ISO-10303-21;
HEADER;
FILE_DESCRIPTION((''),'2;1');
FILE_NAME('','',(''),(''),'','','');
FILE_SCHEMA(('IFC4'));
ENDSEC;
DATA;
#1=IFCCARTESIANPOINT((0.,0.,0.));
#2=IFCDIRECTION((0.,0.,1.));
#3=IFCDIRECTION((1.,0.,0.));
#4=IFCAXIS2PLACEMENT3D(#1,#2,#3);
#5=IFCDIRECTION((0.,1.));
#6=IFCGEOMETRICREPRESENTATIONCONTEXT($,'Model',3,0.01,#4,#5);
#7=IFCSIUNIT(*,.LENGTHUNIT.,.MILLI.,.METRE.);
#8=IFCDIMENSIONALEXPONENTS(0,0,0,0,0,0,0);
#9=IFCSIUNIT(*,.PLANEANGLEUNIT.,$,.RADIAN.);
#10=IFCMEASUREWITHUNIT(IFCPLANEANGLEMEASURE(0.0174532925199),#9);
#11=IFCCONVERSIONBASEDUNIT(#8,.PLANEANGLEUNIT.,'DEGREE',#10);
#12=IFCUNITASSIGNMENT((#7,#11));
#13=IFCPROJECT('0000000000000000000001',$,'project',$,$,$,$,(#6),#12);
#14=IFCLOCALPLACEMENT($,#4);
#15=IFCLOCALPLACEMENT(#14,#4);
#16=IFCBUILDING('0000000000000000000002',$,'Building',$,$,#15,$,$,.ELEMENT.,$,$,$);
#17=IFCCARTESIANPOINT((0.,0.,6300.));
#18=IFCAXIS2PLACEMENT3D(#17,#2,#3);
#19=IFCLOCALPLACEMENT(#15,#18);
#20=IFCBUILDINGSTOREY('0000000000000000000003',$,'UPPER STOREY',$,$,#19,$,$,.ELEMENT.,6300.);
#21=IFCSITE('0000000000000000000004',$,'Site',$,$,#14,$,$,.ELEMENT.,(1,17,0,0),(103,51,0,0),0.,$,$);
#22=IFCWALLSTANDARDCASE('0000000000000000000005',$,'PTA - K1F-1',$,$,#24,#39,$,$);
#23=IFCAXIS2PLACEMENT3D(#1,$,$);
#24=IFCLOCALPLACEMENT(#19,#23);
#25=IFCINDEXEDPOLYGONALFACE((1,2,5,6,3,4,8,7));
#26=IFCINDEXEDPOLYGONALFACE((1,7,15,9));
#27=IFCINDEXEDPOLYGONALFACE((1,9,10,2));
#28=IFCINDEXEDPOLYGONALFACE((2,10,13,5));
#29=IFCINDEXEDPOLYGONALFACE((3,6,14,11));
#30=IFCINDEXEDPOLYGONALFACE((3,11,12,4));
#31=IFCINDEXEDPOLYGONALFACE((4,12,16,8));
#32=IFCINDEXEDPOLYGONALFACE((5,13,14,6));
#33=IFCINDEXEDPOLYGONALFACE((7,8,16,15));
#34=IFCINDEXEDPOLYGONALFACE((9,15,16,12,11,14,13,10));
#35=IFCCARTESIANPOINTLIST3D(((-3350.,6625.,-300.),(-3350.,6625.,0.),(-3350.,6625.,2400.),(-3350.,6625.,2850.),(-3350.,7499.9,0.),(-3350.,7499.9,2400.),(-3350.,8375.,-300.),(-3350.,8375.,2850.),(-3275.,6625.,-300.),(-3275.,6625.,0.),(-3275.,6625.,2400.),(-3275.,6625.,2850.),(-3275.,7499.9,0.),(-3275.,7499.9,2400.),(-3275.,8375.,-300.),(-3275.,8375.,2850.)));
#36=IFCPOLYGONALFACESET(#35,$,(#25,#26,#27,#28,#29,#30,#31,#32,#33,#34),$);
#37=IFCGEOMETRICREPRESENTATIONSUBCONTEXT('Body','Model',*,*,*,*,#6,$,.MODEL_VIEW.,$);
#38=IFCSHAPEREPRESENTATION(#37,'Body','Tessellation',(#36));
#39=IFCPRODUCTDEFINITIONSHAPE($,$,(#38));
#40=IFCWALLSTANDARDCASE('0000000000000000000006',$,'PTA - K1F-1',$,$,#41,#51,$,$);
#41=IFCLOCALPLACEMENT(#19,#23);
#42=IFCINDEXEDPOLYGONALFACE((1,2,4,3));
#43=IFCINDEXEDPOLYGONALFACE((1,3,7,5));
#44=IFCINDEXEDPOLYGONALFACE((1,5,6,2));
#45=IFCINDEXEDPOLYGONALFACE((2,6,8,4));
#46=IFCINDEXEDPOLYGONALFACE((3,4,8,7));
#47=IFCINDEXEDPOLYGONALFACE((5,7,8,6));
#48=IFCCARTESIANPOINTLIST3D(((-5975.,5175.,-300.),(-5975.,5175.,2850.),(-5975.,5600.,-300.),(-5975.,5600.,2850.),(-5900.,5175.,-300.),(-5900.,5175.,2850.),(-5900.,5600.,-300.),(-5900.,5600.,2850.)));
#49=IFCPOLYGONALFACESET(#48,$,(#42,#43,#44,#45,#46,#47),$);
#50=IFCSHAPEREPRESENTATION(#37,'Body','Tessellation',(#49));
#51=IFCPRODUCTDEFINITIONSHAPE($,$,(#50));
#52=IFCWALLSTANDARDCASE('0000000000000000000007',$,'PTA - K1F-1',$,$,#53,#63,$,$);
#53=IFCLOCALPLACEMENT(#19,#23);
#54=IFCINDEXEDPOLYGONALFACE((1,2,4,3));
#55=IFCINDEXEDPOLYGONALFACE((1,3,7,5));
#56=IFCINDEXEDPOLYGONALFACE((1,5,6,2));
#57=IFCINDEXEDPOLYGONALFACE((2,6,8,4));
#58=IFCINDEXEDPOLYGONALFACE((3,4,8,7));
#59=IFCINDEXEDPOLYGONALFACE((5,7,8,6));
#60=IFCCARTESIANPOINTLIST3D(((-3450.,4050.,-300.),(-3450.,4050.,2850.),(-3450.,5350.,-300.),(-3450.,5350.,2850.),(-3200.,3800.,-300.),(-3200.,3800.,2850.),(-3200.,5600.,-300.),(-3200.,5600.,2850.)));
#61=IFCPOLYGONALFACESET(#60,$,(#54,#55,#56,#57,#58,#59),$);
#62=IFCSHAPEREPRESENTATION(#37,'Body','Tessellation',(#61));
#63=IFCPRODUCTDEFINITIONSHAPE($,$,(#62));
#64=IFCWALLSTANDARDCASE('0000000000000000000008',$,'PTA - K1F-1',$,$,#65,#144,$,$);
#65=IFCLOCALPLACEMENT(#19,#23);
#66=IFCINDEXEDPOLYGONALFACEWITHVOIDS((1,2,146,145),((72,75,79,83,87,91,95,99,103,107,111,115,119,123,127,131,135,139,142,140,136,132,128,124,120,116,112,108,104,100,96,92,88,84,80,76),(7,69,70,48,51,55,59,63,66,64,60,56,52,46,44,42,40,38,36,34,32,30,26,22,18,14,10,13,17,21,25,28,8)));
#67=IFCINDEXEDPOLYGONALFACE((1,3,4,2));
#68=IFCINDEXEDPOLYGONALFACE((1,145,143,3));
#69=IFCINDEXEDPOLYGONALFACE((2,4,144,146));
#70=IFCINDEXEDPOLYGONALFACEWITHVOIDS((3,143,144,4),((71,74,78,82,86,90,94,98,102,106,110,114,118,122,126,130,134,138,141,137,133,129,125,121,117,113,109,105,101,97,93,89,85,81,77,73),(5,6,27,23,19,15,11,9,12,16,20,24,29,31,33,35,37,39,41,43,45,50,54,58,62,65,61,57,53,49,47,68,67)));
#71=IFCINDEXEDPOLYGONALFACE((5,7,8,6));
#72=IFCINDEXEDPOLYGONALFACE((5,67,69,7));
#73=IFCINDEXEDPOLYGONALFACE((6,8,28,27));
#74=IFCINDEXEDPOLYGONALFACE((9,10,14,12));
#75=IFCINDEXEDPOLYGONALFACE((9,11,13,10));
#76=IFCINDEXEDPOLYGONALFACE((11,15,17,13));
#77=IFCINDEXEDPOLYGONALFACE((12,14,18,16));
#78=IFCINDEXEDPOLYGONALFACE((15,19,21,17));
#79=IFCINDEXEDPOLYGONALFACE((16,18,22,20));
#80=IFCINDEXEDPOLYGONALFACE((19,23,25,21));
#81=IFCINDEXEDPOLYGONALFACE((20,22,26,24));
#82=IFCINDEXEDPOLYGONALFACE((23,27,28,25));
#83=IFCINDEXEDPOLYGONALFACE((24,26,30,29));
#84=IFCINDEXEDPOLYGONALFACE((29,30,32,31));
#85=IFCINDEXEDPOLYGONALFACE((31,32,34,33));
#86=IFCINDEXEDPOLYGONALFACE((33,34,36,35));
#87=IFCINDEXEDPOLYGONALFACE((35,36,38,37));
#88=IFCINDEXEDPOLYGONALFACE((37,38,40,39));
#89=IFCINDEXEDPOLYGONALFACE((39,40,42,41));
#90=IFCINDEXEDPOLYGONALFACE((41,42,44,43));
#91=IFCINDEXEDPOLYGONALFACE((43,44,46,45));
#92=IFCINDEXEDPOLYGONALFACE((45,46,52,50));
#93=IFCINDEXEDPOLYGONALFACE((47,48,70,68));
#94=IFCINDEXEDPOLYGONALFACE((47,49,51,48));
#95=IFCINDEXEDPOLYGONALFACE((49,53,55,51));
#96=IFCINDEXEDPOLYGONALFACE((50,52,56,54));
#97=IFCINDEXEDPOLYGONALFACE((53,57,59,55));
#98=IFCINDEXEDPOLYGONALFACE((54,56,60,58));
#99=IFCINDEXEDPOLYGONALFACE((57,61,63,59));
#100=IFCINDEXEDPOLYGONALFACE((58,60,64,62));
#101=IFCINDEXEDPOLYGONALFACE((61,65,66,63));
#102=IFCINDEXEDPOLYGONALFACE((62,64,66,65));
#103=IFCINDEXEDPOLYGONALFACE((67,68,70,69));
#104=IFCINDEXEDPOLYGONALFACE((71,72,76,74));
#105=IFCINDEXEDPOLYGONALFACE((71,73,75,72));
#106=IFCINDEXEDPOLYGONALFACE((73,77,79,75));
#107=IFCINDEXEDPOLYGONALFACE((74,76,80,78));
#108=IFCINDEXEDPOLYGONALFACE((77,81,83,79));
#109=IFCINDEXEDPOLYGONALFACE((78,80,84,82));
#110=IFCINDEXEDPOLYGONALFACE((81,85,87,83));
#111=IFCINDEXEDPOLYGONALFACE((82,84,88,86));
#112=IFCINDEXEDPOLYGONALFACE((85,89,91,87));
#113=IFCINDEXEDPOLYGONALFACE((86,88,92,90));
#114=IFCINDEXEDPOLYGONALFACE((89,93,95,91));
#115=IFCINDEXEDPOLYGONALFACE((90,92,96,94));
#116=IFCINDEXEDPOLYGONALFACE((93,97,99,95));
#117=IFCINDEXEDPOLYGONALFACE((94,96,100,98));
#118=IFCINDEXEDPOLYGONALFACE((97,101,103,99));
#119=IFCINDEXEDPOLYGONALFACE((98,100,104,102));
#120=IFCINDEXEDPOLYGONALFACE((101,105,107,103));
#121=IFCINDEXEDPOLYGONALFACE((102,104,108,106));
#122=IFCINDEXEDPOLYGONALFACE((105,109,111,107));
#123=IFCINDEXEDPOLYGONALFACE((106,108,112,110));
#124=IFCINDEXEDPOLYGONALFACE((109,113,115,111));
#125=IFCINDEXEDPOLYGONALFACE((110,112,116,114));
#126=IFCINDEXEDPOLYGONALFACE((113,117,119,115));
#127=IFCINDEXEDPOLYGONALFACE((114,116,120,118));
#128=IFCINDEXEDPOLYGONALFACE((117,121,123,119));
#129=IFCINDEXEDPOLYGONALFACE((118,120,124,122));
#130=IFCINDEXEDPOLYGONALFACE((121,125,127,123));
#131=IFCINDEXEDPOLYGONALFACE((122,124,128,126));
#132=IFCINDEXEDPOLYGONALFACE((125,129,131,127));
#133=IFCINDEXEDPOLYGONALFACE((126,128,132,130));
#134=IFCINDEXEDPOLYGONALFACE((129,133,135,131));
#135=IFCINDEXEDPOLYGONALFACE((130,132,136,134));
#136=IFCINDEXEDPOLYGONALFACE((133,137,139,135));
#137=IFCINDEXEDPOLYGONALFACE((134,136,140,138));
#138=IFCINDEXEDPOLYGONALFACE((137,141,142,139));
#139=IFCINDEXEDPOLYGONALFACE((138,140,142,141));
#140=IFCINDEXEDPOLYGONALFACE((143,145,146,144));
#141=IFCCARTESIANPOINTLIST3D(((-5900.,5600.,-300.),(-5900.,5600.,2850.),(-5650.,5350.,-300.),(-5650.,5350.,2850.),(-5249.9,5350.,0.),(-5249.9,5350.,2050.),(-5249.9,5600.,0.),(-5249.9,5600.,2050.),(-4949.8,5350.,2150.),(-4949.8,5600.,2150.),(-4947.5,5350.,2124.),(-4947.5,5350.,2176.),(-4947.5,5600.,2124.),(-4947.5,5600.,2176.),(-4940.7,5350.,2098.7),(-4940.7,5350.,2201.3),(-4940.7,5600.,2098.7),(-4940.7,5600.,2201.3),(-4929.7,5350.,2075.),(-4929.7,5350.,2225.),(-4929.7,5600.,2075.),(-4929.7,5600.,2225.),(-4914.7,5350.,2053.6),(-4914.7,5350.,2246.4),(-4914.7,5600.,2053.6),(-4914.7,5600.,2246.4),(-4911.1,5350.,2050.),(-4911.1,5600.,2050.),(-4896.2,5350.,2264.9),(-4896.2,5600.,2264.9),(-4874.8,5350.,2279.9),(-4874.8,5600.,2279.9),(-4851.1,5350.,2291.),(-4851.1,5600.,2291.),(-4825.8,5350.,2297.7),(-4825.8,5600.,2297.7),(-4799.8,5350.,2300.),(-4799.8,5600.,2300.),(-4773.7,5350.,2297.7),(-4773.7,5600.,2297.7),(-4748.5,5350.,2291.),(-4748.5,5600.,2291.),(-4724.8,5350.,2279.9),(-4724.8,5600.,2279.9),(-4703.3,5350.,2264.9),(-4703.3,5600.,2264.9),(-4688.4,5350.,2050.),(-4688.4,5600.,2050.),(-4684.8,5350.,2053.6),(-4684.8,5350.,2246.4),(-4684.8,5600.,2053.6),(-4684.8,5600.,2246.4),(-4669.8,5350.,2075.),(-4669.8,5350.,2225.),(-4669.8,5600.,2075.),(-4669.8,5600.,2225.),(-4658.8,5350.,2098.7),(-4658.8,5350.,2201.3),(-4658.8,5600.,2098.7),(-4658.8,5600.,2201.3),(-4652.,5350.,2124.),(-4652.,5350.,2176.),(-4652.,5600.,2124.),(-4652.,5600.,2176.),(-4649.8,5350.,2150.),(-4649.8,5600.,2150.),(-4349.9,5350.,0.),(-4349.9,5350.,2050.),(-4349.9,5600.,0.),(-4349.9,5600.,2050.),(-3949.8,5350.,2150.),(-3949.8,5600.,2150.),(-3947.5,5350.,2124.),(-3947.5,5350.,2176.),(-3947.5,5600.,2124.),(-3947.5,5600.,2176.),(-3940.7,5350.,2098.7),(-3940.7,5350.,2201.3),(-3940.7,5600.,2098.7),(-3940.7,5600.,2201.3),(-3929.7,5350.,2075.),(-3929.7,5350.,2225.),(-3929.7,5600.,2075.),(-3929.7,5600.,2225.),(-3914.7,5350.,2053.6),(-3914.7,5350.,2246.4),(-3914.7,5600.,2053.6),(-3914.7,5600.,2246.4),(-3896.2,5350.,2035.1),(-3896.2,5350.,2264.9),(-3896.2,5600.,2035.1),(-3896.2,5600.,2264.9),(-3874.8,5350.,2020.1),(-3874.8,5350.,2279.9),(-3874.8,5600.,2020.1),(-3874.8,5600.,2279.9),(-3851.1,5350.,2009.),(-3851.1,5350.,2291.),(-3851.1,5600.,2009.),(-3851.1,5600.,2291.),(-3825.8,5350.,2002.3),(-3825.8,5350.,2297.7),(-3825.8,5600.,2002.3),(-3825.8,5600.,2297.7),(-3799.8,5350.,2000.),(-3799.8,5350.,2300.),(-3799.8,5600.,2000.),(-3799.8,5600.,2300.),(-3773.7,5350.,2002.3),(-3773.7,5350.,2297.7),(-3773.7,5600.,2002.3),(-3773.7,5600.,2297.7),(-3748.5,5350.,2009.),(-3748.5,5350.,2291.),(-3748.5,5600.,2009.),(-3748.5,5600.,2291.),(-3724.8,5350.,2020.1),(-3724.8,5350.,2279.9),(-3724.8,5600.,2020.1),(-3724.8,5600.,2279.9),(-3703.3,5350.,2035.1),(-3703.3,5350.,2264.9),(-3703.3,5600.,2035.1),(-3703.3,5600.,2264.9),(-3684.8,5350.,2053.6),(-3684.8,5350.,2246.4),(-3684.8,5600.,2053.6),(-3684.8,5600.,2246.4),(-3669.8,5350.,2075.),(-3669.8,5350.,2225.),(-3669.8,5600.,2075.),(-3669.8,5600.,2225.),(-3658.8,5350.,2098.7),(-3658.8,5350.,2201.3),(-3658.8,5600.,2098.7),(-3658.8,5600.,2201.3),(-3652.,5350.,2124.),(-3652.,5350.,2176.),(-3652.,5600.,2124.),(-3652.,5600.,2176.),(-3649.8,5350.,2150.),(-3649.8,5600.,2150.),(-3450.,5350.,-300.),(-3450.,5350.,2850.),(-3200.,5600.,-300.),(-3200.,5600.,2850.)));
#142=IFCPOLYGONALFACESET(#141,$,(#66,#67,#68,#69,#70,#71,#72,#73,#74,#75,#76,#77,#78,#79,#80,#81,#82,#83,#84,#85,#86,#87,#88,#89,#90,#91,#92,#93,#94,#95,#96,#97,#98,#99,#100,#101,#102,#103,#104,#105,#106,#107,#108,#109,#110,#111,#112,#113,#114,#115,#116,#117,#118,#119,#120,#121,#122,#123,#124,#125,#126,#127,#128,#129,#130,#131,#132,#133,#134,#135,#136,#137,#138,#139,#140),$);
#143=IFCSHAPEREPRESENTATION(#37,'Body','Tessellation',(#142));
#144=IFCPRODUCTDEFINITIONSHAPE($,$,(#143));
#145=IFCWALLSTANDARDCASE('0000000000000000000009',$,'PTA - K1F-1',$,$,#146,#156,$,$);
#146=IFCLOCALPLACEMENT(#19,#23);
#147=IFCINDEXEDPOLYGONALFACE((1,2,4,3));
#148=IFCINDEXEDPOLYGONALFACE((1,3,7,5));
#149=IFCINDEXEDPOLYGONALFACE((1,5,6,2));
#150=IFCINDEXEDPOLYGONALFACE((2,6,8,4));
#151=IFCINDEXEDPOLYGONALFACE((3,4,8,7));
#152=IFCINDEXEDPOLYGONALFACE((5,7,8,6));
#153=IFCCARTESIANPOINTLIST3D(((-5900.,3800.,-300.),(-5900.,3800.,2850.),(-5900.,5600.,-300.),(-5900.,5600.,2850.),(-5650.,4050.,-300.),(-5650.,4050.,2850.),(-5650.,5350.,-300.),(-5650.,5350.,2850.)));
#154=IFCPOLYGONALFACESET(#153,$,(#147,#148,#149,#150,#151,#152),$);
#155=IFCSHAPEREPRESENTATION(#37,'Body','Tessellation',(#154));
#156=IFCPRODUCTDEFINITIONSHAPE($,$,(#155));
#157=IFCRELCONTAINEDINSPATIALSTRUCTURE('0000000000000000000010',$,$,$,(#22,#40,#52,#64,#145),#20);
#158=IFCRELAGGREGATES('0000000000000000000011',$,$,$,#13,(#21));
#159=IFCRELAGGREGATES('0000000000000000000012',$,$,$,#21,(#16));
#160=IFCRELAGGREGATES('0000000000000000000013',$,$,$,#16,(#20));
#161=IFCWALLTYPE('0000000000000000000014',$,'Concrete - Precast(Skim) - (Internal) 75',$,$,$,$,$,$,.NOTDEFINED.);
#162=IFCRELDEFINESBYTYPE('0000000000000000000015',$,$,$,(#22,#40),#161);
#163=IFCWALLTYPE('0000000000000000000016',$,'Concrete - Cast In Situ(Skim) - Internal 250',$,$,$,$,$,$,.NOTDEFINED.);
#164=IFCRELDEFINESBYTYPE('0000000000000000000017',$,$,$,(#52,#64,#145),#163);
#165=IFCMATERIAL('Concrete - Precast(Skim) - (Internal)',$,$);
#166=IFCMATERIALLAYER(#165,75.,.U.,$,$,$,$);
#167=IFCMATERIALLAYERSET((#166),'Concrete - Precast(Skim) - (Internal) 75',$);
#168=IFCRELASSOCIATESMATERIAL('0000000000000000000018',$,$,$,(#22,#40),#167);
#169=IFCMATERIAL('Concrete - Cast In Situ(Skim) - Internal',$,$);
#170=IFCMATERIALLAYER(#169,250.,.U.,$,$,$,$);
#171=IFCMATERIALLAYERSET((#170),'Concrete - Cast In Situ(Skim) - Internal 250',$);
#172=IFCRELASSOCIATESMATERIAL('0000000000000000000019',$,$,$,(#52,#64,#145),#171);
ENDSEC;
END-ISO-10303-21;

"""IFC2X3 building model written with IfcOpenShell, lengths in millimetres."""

from ifc_helpers import new_model, entity, si_unit, converted_unit, direction, frame, origin_with_axes, origin_2d_with_axis, place, context, subcontext, project, spatial, polyline, rectangle, outline, extrude, material, layer, layer_set, layer_usage, type_object, element, save


model = new_model("IFC2X3")

# Units and contexts
model_context = context("Model", 3, precision=0.01, world=origin_with_axes(), true_north=direction((0.0, 1.0)))
body_context = subcontext(model_context, "Body", "Model", "MODEL_VIEW")
ifc_project = project(units=[si_unit("LENGTHUNIT", "METRE", prefix="MILLI"), converted_unit("PLANEANGLEUNIT", "DEGREE", entity("IfcPlaneAngleMeasure", 0.0174532925199), si_unit("PLANEANGLEUNIT", "RADIAN"), dimensions=[0, 0, 0, 0, 0, 0, 0])], contexts=[model_context])

# Site, building, storey
site_placement = place(None, origin_with_axes())
site = spatial("IfcSite", under=ifc_project, at=site_placement, Name="Site", CompositionType="ELEMENT", RefLatitude=(1, 17, 0, 0), RefLongitude=(103, 51, 0, 0), RefElevation=0.0)
building_placement = place(site_placement, origin_with_axes())
building = spatial("IfcBuilding", under=site, at=building_placement, Name="Building", CompositionType="ELEMENT")
storey_placement = place(building_placement, frame((0.0, 0.0, 6300.0), z_axis=(0.0, 0.0, 1.0), x_axis=(1.0, 0.0, 0.0)))
storey = spatial("IfcBuildingStorey", under=building, at=storey_placement, Name="UPPER STOREY", CompositionType="ELEMENT", Elevation=6300.0)

# Shared definitions
ifc_material_1 = material(Name="Concrete - Cast In Situ(Skim) - Internal")

# Shared definitions
ifc_material_2 = material(Name="Concrete - Precast(Skim) - (Internal)")

# Wall, opening
ifc_layer_1 = layer(ifc_material_2, 75.0, ventilated="UNKNOWN")
ifc_layer_set_1 = layer_set([ifc_layer_1], Name="Concrete - Precast(Skim) - (Internal) 75")
ifc_layer_usage_1 = layer_usage(ifc_layer_set_1, "AXIS2", "POSITIVE", 0.0)
wall_type_1 = type_object("IfcWallType", Name="Concrete - Precast(Skim) - (Internal) 75", PredefinedType="NOTDEFINED")
wall_1_placement = place(storey_placement, frame((-3275.0, 6625.0, -300.0), z_axis=(0.0, 0.0, 1.0), x_axis=(-0.000002, 1.0, 0.0)))
wall_1 = element("IfcWallStandardCase", 1, at=wall_1_placement, inside=storey, type_object=wall_type_1, material=ifc_layer_usage_1, Name="PTA - K1F-1", context=body_context, shape_type="SweptSolid", body=[
    extrude(outline(polyline([(0.0, 0.0), (1750.0, 0.0), (1750.0, 75.0), (0.0, 75.0), (0.0, 0.0)])), origin_with_axes(), (0.0, 0.0, 1.0), 3150.0),
])
opening_1_placement = place(wall_1_placement, frame((424.8, 0.0, 300.0), z_axis=(0.0, 0.0, 1.0), x_axis=(1.0, 0.0, 0.0)))
element("IfcOpeningElement", 2, at=opening_1_placement, cuts=wall_1, context=body_context, shape_type="SweptSolid", body=[
    extrude(rectangle(XDim=900.1, YDim=2400.0, at=origin_2d_with_axis()), frame((0.0, 75.0, 1200.0), z_axis=(0.0, 1.0, 0.0), x_axis=(1.0, 0.0, 0.0)), (0.0, 0.0, -1.0), 225.0),
])

# Walls
ifc_layer_usage_2 = layer_usage(ifc_layer_set_1, "AXIS2", "NEGATIVE", 0.0)
wall_2_placement = place(storey_placement, frame((-5975.0, 5175.0, -300.0), z_axis=(0.0, 0.0, 1.0), x_axis=(0.0, 1.0, 0.0)))
element("IfcWallStandardCase", 3, at=wall_2_placement, inside=storey, type_object=wall_type_1, material=ifc_layer_usage_2, Name="PTA - K1F-1", context=body_context, shape_type="SweptSolid", body=[
    extrude(outline(polyline([(0.0, -75.0), (425.0, -75.0), (425.0, 0.0), (0.0, 0.0), (0.0, -75.0)])), origin_with_axes(), (0.0, 0.0, 1.0), 3150.0),
])
ifc_layer_2 = layer(ifc_material_1, 250.0, ventilated="UNKNOWN")
ifc_layer_set_2 = layer_set([ifc_layer_2], Name="Concrete - Cast In Situ(Skim) - Internal 250")
ifc_layer_usage_3 = layer_usage(ifc_layer_set_2, "AXIS2", "NEGATIVE", 0.0)
wall_type_2 = type_object("IfcWallType", Name="Concrete - Cast In Situ(Skim) - Internal 250", PredefinedType="NOTDEFINED")
wall_3_placement = place(storey_placement, frame((-3200.0, 5600.0, -300.0), z_axis=(0.0, 0.0, 1.0), x_axis=(0.0, -1.0, 0.0)))
element("IfcWallStandardCase", 4, at=wall_3_placement, inside=storey, type_object=wall_type_2, material=ifc_layer_usage_3, Name="PTA - K1F-1", context=body_context, shape_type="SweptSolid", body=[
    extrude(outline(polyline([(250.0, -250.0), (1550.0, -250.0), (1800.0, 0.0), (0.0, 0.0), (250.0, -250.0)])), origin_with_axes(), (0.0, 0.0, 1.0), 3150.0),
])

# Wall, openings
ifc_layer_usage_4 = layer_usage(ifc_layer_set_2, "AXIS2", "POSITIVE", 0.0)
wall_4_placement = place(storey_placement, frame((-3200.0, 5600.0, -300.0), z_axis=(0.0, 0.0, 1.0), x_axis=(-1.0, 0.0, 0.0)))
wall_4 = element("IfcWallStandardCase", 5, at=wall_4_placement, inside=storey, type_object=wall_type_2, material=ifc_layer_usage_4, Name="PTA - K1F-1", context=body_context, shape_type="SweptSolid", body=[
    extrude(outline(polyline([(0.0, 0.0), (2700.0, 0.0), (2450.0, 250.0), (250.0, 250.0), (0.0, 0.0)])), origin_with_axes(), (0.0, 0.0, 1.0), 3150.0),
])
opening_2_placement = place(wall_4_placement, frame((1599.8, 0.0, 2450.0), z_axis=(0.0, 0.0, 1.0), x_axis=(1.0, 0.0, 0.0)))
element("IfcOpeningElement", 6, at=opening_2_placement, cuts=wall_4, context=body_context, shape_type="SweptSolid", body=[
    extrude(outline(polyline([(-150.0, 0.0), (-147.7, -26.0), (-141.0, -51.3), (-129.9, -75.0), (-114.9, -96.4), (-96.4, -114.9), (-75.0, -129.9), (-51.3, -141.0), (-26.0, -147.7), (0.0, -150.0), (26.0, -147.7), (51.3, -141.0), (75.0, -129.9), (96.4, -114.9), (114.9, -96.4), (129.9, -75.0), (141.0, -51.3), (147.7, -26.0), (150.0, 0.0), (147.7, 26.0), (141.0, 51.3), (129.9, 75.0), (114.9, 96.4), (96.4, 114.9), (75.0, 129.9), (51.3, 141.0), (26.0, 147.7), (0.0, 150.0), (-26.0, 147.7), (-51.3, 141.0), (-75.0, 129.9), (-96.4, 114.9), (-114.9, 96.4), (-129.9, 75.0), (-141.0, 51.3), (-147.7, 26.0), (-150.0, 0.0)])), frame((0.0, 250.0, 0.0), z_axis=(0.0, -1.0, 0.0), x_axis=(-1.0, 0.0, 0.0)), (0.0, 0.0, 1.0), 500.0),
])
opening_3_placement = place(wall_4_placement, frame((599.8, 0.0, 2450.0), z_axis=(0.0, 0.0, 1.0), x_axis=(1.0, 0.0, 0.0)))
element("IfcOpeningElement", 7, at=opening_3_placement, cuts=wall_4, context=body_context, shape_type="SweptSolid", body=[
    extrude(outline(polyline([(-150.0, 0.0), (-147.7, -26.0), (-141.0, -51.3), (-129.9, -75.0), (-114.9, -96.4), (-96.4, -114.9), (-75.0, -129.9), (-51.3, -141.0), (-26.0, -147.7), (0.0, -150.0), (26.0, -147.7), (51.3, -141.0), (75.0, -129.9), (96.4, -114.9), (114.9, -96.4), (129.9, -75.0), (141.0, -51.3), (147.7, -26.0), (150.0, 0.0), (147.7, 26.0), (141.0, 51.3), (129.9, 75.0), (114.9, 96.4), (96.4, 114.9), (75.0, 129.9), (51.3, 141.0), (26.0, 147.7), (0.0, 150.0), (-26.0, 147.7), (-51.3, 141.0), (-75.0, 129.9), (-96.4, 114.9), (-114.9, 96.4), (-129.9, 75.0), (-141.0, 51.3), (-147.7, 26.0), (-150.0, 0.0)])), frame((0.0, 250.0, 0.0), z_axis=(0.0, -1.0, 0.0), x_axis=(-1.0, 0.0, 0.0)), (0.0, 0.0, 1.0), 500.0),
])
opening_4_placement = place(wall_4_placement, frame((1599.9, 0.0, 300.0), z_axis=(0.0, 0.0, 1.0), x_axis=(1.0, 0.0, 0.0)))
element("IfcOpeningElement", 8, at=opening_4_placement, cuts=wall_4, context=body_context, shape_type="SweptSolid", body=[
    extrude(rectangle(XDim=900.0, YDim=2050.0, at=origin_2d_with_axis()), frame((0.0, 250.0, 1025.0), z_axis=(0.0, -1.0, 0.0), x_axis=(-1.0, 0.0, 0.0)), (0.0, 0.0, 1.0), 750.0),
])
opening_5_placement = place(wall_4_placement, frame((1599.9, 0.0, 300.0), z_axis=(0.0, 0.0, 1.0), x_axis=(1.0, 0.0, 0.0)))
element("IfcOpeningElement", 9, at=opening_5_placement, cuts=wall_4, context=body_context, shape_type="SweptSolid", body=[
    extrude(rectangle(XDim=800.0, YDim=1975.0, at=origin_2d_with_axis()), frame((0.0, -250.0, 987.5), z_axis=(0.0, 1.0, 0.0), x_axis=(1.0, 0.0, 0.0)), (0.0, 0.0, 1.0), 750.0),
])

# Wall
ifc_layer_usage_5 = layer_usage(ifc_layer_set_2, "AXIS2", "POSITIVE", 0.0)
wall_5_placement = place(storey_placement, frame((-5900.0, 5600.0, -300.0), z_axis=(0.0, 0.0, 1.0), x_axis=(0.0, -1.0, 0.0)))
element("IfcWallStandardCase", 10, at=wall_5_placement, inside=storey, type_object=wall_type_2, material=ifc_layer_usage_5, Name="PTA - K1F-1", context=body_context, shape_type="SweptSolid", body=[
    extrude(outline(polyline([(0.0, 0.0), (1800.0, 0.0), (1550.0, 250.0), (250.0, 250.0), (0.0, 0.0)])), origin_with_axes(), (0.0, 0.0, 1.0), 3150.0),
])

save(model, "model.ifc")
